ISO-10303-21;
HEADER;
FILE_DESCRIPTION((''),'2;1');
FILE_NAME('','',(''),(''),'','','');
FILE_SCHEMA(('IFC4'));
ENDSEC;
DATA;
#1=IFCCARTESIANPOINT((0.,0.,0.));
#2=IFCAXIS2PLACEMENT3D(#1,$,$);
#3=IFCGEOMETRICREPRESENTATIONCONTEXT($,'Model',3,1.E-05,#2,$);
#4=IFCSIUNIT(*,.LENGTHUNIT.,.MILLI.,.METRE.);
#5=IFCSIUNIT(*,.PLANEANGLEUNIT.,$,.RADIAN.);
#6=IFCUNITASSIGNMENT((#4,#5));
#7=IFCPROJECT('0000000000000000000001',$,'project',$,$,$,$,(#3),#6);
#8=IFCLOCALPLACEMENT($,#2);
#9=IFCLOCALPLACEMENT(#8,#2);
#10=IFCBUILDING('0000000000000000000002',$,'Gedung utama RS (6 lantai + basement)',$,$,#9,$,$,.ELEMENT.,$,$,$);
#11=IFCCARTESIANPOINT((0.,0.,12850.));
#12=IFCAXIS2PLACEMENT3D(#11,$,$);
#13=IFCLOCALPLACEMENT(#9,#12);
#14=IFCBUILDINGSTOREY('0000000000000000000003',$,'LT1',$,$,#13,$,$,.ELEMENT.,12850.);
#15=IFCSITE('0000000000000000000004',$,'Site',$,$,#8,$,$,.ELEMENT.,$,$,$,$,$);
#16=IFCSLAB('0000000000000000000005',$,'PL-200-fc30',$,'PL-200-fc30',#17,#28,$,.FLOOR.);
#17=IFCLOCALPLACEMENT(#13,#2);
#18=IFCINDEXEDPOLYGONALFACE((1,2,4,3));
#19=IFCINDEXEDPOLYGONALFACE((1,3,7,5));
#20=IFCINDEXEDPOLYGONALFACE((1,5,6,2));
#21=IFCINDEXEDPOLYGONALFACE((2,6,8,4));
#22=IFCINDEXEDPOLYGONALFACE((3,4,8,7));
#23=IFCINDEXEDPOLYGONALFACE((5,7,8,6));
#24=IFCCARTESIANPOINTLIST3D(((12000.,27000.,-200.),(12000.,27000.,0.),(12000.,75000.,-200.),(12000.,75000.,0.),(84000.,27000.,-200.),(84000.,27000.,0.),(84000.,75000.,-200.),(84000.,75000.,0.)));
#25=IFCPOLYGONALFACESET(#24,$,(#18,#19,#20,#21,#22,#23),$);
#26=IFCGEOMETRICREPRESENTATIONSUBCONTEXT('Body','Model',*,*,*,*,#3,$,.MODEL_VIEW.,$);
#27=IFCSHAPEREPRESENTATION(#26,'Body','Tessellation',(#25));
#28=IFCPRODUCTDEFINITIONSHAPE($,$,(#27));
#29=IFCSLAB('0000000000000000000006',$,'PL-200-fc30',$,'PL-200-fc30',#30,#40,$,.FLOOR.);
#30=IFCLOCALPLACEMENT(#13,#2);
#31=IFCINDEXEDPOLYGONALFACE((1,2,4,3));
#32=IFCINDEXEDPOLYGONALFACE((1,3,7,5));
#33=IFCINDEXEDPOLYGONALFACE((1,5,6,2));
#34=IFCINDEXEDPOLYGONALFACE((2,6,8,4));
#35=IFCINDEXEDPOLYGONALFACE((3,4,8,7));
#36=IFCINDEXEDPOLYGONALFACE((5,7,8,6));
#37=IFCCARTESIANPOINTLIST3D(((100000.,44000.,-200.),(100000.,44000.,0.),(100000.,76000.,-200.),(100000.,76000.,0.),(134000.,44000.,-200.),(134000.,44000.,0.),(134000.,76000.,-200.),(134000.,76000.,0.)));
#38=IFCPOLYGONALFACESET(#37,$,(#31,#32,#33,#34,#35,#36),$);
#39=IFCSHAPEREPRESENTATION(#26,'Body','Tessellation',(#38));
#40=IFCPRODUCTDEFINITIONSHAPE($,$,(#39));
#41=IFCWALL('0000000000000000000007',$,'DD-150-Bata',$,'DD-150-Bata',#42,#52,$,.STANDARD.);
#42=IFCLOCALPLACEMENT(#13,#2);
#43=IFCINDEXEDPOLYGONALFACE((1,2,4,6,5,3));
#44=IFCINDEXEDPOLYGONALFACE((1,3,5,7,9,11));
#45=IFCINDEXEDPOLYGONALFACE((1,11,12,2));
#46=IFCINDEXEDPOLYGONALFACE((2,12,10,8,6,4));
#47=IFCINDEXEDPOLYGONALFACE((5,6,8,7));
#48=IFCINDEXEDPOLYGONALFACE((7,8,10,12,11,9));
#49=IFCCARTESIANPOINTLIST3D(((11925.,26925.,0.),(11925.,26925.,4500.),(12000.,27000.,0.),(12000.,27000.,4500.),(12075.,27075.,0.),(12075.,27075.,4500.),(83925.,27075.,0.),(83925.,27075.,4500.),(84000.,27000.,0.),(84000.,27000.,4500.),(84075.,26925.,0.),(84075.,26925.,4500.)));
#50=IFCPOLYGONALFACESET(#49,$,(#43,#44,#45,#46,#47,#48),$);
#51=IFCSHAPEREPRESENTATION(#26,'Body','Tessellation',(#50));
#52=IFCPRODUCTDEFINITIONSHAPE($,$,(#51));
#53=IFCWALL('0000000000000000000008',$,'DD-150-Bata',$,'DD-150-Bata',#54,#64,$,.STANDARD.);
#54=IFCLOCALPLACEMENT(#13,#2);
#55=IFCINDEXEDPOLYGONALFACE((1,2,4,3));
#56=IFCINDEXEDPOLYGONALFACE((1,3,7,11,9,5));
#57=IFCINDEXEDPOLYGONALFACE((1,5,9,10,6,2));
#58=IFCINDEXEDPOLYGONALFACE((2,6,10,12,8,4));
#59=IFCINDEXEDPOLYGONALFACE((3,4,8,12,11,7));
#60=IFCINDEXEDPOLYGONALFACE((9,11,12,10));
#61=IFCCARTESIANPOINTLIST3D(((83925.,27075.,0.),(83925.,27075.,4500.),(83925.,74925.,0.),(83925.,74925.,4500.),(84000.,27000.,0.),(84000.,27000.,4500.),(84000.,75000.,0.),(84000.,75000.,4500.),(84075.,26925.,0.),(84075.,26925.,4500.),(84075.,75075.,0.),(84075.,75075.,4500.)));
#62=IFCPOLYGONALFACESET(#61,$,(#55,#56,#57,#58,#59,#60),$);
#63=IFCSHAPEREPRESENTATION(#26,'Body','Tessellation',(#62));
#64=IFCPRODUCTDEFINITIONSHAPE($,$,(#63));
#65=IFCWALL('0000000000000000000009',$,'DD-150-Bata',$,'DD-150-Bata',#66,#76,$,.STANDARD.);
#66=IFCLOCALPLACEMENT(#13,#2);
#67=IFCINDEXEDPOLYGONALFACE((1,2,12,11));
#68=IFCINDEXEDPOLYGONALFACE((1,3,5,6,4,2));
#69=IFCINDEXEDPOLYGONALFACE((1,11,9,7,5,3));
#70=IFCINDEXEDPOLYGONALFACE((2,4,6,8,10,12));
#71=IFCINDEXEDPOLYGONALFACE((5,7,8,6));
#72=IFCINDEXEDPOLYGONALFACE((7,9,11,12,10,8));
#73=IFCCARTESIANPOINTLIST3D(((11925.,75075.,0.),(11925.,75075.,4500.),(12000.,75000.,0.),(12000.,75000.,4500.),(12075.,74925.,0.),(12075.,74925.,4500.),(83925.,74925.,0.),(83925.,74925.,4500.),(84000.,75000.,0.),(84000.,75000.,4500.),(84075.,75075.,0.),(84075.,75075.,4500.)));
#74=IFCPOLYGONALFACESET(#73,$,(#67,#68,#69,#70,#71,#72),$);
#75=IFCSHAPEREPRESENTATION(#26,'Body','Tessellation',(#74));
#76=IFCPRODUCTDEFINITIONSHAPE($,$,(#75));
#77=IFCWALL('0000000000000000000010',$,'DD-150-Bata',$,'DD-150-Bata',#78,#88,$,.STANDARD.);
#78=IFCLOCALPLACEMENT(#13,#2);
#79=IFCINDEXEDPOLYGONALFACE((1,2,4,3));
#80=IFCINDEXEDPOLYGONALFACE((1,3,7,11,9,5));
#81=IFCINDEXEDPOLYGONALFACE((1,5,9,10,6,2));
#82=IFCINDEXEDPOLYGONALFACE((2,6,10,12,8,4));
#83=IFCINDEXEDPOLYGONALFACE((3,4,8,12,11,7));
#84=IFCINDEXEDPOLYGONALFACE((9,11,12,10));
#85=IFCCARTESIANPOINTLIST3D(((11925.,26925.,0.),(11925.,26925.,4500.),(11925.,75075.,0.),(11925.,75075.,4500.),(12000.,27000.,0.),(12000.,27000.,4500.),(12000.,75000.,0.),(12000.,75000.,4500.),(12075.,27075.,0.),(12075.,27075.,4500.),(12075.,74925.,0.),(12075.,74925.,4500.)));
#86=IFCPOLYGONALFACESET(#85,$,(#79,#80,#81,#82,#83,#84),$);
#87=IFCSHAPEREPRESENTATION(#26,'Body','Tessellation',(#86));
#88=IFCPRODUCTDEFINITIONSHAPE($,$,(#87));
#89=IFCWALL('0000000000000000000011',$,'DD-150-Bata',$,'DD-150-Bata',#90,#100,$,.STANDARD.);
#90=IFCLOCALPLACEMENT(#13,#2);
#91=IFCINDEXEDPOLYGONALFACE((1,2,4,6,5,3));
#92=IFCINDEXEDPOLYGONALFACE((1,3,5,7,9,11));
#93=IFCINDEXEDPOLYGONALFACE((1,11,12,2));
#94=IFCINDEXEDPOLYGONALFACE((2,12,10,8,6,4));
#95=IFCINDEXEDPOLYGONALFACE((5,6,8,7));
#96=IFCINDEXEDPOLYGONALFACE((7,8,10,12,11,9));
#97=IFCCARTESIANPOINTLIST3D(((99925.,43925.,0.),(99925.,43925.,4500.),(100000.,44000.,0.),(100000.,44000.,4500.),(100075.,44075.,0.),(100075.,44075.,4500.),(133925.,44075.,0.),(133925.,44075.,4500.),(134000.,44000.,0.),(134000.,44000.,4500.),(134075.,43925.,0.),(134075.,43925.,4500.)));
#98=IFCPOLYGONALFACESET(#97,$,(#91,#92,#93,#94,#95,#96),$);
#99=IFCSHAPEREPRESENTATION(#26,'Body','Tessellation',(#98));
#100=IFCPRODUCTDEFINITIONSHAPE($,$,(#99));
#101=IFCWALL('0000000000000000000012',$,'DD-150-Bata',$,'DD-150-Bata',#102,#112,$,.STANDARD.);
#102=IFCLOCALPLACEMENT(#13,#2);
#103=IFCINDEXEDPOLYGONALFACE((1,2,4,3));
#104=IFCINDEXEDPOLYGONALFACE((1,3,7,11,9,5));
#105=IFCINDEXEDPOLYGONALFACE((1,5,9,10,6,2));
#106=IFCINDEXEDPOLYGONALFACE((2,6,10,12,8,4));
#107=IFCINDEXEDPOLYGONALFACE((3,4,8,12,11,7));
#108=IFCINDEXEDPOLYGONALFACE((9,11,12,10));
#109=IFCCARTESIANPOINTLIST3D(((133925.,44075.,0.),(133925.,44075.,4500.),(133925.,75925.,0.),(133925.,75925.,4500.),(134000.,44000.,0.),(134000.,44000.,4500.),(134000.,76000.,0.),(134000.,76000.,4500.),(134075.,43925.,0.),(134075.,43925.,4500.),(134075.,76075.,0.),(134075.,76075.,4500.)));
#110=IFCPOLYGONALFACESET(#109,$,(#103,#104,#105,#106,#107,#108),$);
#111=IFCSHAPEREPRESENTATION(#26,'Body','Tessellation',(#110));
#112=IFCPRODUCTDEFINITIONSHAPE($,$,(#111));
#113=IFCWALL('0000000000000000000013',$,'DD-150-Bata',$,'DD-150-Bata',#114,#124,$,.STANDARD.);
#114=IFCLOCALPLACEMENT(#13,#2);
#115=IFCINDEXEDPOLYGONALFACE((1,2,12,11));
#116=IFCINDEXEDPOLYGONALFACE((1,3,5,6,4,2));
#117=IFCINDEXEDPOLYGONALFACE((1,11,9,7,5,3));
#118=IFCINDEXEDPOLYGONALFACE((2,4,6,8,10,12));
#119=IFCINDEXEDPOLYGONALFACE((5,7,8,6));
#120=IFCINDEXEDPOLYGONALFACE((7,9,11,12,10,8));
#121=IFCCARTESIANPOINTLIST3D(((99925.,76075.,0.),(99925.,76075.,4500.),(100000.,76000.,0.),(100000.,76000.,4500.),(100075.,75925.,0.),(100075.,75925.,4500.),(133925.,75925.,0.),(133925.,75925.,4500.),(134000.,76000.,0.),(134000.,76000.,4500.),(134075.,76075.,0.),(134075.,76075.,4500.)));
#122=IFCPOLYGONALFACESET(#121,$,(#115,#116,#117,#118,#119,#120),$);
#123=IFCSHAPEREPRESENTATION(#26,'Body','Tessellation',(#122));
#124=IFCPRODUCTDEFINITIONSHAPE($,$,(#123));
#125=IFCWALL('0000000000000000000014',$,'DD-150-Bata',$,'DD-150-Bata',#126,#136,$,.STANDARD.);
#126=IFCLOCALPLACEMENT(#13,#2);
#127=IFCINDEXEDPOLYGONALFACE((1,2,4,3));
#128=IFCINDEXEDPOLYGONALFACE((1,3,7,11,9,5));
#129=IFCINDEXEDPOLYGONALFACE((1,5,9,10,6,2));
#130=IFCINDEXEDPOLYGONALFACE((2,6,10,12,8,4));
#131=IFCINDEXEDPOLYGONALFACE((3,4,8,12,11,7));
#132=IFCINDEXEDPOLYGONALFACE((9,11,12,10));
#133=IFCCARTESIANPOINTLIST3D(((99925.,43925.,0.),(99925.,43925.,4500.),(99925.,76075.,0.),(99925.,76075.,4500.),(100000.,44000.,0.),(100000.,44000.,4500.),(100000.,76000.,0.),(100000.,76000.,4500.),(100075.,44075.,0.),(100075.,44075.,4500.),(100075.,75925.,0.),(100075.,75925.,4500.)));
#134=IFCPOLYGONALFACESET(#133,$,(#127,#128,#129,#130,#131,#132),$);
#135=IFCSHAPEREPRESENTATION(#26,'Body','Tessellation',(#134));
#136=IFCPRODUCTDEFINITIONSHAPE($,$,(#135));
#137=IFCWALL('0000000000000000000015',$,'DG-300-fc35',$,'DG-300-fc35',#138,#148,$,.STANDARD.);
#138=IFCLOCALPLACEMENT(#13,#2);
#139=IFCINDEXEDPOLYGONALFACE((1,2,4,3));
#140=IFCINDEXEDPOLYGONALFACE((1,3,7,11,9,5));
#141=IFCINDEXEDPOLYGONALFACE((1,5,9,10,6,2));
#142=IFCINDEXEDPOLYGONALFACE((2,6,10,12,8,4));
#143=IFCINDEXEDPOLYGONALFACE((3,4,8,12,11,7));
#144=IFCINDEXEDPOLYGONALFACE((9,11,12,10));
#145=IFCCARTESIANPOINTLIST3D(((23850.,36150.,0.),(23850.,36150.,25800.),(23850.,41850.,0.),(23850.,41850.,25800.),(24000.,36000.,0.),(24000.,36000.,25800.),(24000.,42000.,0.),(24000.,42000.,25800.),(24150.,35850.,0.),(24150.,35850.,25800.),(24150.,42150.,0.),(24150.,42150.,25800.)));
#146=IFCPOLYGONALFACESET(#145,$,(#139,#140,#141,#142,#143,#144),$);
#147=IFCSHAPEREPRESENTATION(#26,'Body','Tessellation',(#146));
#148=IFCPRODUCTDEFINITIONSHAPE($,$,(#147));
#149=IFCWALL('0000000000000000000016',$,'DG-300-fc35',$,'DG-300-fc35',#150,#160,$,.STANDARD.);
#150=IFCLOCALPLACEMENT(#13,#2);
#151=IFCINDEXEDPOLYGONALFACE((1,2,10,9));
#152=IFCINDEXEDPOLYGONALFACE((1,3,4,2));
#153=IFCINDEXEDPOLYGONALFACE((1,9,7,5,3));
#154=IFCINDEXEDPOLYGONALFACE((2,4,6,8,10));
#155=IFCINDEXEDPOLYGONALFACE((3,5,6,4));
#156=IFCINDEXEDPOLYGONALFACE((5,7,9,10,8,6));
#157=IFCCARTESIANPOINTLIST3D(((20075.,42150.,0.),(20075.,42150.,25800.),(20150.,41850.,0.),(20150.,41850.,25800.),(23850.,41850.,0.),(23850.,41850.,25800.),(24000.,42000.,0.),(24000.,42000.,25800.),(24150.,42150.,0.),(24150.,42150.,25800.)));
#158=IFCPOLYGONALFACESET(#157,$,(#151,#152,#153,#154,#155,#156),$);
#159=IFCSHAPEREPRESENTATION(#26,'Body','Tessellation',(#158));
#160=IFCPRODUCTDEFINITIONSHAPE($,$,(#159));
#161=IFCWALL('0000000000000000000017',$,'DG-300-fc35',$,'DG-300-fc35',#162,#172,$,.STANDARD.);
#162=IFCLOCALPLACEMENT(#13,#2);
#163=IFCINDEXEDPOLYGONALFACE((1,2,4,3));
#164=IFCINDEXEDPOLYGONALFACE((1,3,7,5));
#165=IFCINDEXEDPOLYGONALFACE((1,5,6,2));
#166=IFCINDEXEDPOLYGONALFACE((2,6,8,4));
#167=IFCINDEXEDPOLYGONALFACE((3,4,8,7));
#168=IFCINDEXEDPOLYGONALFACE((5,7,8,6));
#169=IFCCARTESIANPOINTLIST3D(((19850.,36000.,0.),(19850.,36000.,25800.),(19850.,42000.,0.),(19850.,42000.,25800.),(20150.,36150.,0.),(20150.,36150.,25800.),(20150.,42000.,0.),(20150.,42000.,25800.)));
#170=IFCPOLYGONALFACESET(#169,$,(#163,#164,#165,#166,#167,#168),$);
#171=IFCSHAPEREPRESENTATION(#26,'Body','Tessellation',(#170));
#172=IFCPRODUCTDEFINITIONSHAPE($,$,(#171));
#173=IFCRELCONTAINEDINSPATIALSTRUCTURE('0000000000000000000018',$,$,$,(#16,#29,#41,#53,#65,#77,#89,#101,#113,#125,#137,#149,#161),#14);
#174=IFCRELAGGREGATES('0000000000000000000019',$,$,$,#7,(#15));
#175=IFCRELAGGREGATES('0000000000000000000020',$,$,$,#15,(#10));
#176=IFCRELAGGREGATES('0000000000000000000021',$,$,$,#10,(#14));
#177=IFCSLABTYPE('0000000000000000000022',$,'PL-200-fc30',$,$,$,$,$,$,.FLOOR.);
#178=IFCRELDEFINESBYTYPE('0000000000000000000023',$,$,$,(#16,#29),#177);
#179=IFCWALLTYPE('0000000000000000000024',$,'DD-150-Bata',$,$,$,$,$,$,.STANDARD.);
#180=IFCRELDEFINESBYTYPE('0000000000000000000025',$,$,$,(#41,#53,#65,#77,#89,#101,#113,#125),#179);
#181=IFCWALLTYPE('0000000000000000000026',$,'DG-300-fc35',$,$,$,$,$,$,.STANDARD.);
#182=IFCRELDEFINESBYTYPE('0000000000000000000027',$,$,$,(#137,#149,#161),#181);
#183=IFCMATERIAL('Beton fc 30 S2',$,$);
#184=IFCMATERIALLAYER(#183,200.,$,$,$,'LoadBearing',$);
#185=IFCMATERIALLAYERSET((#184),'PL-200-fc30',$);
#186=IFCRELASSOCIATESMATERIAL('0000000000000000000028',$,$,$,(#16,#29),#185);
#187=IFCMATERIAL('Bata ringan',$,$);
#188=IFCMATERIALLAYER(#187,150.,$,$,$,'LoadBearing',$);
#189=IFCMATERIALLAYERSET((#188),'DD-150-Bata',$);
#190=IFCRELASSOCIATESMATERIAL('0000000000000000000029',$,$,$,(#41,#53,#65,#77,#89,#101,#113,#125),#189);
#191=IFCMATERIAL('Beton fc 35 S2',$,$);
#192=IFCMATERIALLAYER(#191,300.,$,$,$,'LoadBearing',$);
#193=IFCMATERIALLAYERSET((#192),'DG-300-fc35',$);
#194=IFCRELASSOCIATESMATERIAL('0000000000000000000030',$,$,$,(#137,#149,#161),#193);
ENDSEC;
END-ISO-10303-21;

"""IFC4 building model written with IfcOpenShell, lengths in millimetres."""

from ifc_helpers import new_model, si_unit, frame, origin, place, context, subcontext, project, spatial, polyline, outline, extrude, material, layer, layer_set, layer_usage, type_object, element, save


model = new_model("IFC4")

# Units and contexts
model_context = context("Model", 3, precision=1e-05, world=origin())
body_context = subcontext(model_context, "Body", "Model", "MODEL_VIEW")
ifc_project = project(units=[si_unit("LENGTHUNIT", "METRE", prefix="MILLI"), si_unit("PLANEANGLEUNIT", "RADIAN")], contexts=[model_context])

# Site, building, storey
site_placement = place(None, origin())
site = spatial("IfcSite", under=ifc_project, at=site_placement, Name="Site", CompositionType="ELEMENT")
building_placement = place(site_placement, origin())
building = spatial("IfcBuilding", under=site, at=building_placement, Name="Gedung utama RS (6 lantai + basement)", CompositionType="ELEMENT")
storey_placement = place(building_placement, frame((0.0, 0.0, 12850.0)))
storey = spatial("IfcBuildingStorey", under=building, at=storey_placement, Name="LT1", CompositionType="ELEMENT", Elevation=12850.0)

# Slabs
ifc_material_1 = material(Name="Beton fc 30 S2")
ifc_layer_1 = layer(ifc_material_1, 200.0, Category="LoadBearing")
ifc_layer_set_1 = layer_set([ifc_layer_1], Name="PL-200-fc30")
ifc_layer_usage_1 = layer_usage(ifc_layer_set_1, "AXIS3", "NEGATIVE", 0.0)
slab_type = type_object("IfcSlabType", Name="PL-200-fc30", PredefinedType="FLOOR")
slab_1_placement = place(storey_placement, origin())
element("IfcSlab", 1, at=slab_1_placement, inside=storey, type_object=slab_type, material=ifc_layer_usage_1, Name="PL-200-fc30", ObjectType="PL-200-fc30", PredefinedType="FLOOR", context=body_context, shape_type="SweptSolid", body=[
    extrude(outline(polyline([(12000.0, 27000.0), (84000.0, 27000.0), (84000.0, 75000.0), (12000.0, 75000.0), (12000.0, 27000.0)])), frame((0.0, 0.0, -200.0)), (0.0, 0.0, 1.0), 200.0),
])
slab_2_placement = place(storey_placement, origin())
element("IfcSlab", 2, at=slab_2_placement, inside=storey, type_object=slab_type, material=ifc_layer_usage_1, Name="PL-200-fc30", ObjectType="PL-200-fc30", PredefinedType="FLOOR", context=body_context, shape_type="SweptSolid", body=[
    extrude(outline(polyline([(100000.0, 44000.0), (134000.0, 44000.0), (134000.0, 76000.0), (100000.0, 76000.0), (100000.0, 44000.0)])), frame((0.0, 0.0, -200.0)), (0.0, 0.0, 1.0), 200.0),
])

# Walls
ifc_material_2 = material(Name="Bata ringan")
ifc_layer_2 = layer(ifc_material_2, 150.0, Category="LoadBearing")
ifc_layer_set_2 = layer_set([ifc_layer_2], Name="DD-150-Bata")
ifc_layer_usage_2 = layer_usage(ifc_layer_set_2, "AXIS2", "NEGATIVE", 75.0)
wall_type_1 = type_object("IfcWallType", Name="DD-150-Bata", PredefinedType="STANDARD")
wall_1_placement = place(storey_placement, frame((12000.0, 27000.0, 0.0), z_axis=(0.0, 0.0, 1.0), x_axis=(1.0, 0.0, 0.0)))
element("IfcWall", 3, at=wall_1_placement, inside=storey, type_object=wall_type_1, material=ifc_layer_usage_2, Name="DD-150-Bata", ObjectType="DD-150-Bata", PredefinedType="STANDARD", context=body_context, shape_type="SweptSolid", body=[
    extrude(outline(polyline([(-75.0, -75.0), (0.0, 0.0), (75.0, 75.0), (71925.0, 75.0), (72000.0, 0.0), (72075.0, -75.0), (-75.0, -75.0)])), origin(), (0.0, 0.0, 1.0), 4500.0),
])
wall_2_placement = place(storey_placement, frame((84000.0, 27000.0, 0.0), z_axis=(0.0, 0.0, 1.0), x_axis=(0.0, 1.0, 0.0)))
element("IfcWall", 4, at=wall_2_placement, inside=storey, type_object=wall_type_1, material=ifc_layer_usage_2, Name="DD-150-Bata", ObjectType="DD-150-Bata", PredefinedType="STANDARD", context=body_context, shape_type="SweptSolid", body=[
    extrude(outline(polyline([(-75.0, -75.0), (0.0, 0.0), (75.0, 75.0), (47925.0, 75.0), (48000.0, 0.0), (48075.0, -75.0), (-75.0, -75.0)])), origin(), (0.0, 0.0, 1.0), 4500.0),
])
wall_3_placement = place(storey_placement, frame((84000.0, 75000.0, 0.0), z_axis=(0.0, 0.0, 1.0), x_axis=(-1.0, 0.0, 0.0)))
element("IfcWall", 5, at=wall_3_placement, inside=storey, type_object=wall_type_1, material=ifc_layer_usage_2, Name="DD-150-Bata", ObjectType="DD-150-Bata", PredefinedType="STANDARD", context=body_context, shape_type="SweptSolid", body=[
    extrude(outline(polyline([(-75.0, -75.0), (0.0, 0.0), (75.0, 75.0), (71925.0, 75.0), (72000.0, 0.0), (72075.0, -75.0), (-75.0, -75.0)])), origin(), (0.0, 0.0, 1.0), 4500.0),
])
wall_4_placement = place(storey_placement, frame((12000.0, 75000.0, 0.0), z_axis=(0.0, 0.0, 1.0), x_axis=(0.0, -1.0, 0.0)))
element("IfcWall", 6, at=wall_4_placement, inside=storey, type_object=wall_type_1, material=ifc_layer_usage_2, Name="DD-150-Bata", ObjectType="DD-150-Bata", PredefinedType="STANDARD", context=body_context, shape_type="SweptSolid", body=[
    extrude(outline(polyline([(-75.0, -75.0), (0.0, 0.0), (75.0, 75.0), (47925.0, 75.0), (48000.0, 0.0), (48075.0, -75.0), (-75.0, -75.0)])), origin(), (0.0, 0.0, 1.0), 4500.0),
])
wall_5_placement = place(storey_placement, frame((100000.0, 44000.0, 0.0), z_axis=(0.0, 0.0, 1.0), x_axis=(1.0, 0.0, 0.0)))
element("IfcWall", 7, at=wall_5_placement, inside=storey, type_object=wall_type_1, material=ifc_layer_usage_2, Name="DD-150-Bata", ObjectType="DD-150-Bata", PredefinedType="STANDARD", context=body_context, shape_type="SweptSolid", body=[
    extrude(outline(polyline([(-75.0, -75.0), (0.0, 0.0), (75.0, 75.0), (33925.0, 75.0), (34000.0, 0.0), (34075.0, -75.0), (-75.0, -75.0)])), origin(), (0.0, 0.0, 1.0), 4500.0),
])
wall_6_placement = place(storey_placement, frame((134000.0, 44000.0, 0.0), z_axis=(0.0, 0.0, 1.0), x_axis=(0.0, 1.0, 0.0)))
element("IfcWall", 8, at=wall_6_placement, inside=storey, type_object=wall_type_1, material=ifc_layer_usage_2, Name="DD-150-Bata", ObjectType="DD-150-Bata", PredefinedType="STANDARD", context=body_context, shape_type="SweptSolid", body=[
    extrude(outline(polyline([(-75.0, -75.0), (0.0, 0.0), (75.0, 75.0), (31925.0, 75.0), (32000.0, 0.0), (32075.0, -75.0), (-75.0, -75.0)])), origin(), (0.0, 0.0, 1.0), 4500.0),
])
wall_7_placement = place(storey_placement, frame((134000.0, 76000.0, 0.0), z_axis=(0.0, 0.0, 1.0), x_axis=(-1.0, 0.0, 0.0)))
element("IfcWall", 9, at=wall_7_placement, inside=storey, type_object=wall_type_1, material=ifc_layer_usage_2, Name="DD-150-Bata", ObjectType="DD-150-Bata", PredefinedType="STANDARD", context=body_context, shape_type="SweptSolid", body=[
    extrude(outline(polyline([(-75.0, -75.0), (0.0, 0.0), (75.0, 75.0), (33925.0, 75.0), (34000.0, 0.0), (34075.0, -75.0), (-75.0, -75.0)])), origin(), (0.0, 0.0, 1.0), 4500.0),
])
wall_8_placement = place(storey_placement, frame((100000.0, 76000.0, 0.0), z_axis=(0.0, 0.0, 1.0), x_axis=(0.0, -1.0, 0.0)))
element("IfcWall", 10, at=wall_8_placement, inside=storey, type_object=wall_type_1, material=ifc_layer_usage_2, Name="DD-150-Bata", ObjectType="DD-150-Bata", PredefinedType="STANDARD", context=body_context, shape_type="SweptSolid", body=[
    extrude(outline(polyline([(-75.0, -75.0), (0.0, 0.0), (75.0, 75.0), (31925.0, 75.0), (32000.0, 0.0), (32075.0, -75.0), (-75.0, -75.0)])), origin(), (0.0, 0.0, 1.0), 4500.0),
])
ifc_material_3 = material(Name="Beton fc 35 S2")
ifc_layer_3 = layer(ifc_material_3, 300.0, Category="LoadBearing")
ifc_layer_set_3 = layer_set([ifc_layer_3], Name="DG-300-fc35")
ifc_layer_usage_3 = layer_usage(ifc_layer_set_3, "AXIS2", "NEGATIVE", 150.0)
wall_type_2 = type_object("IfcWallType", Name="DG-300-fc35", PredefinedType="STANDARD")
wall_9_placement = place(storey_placement, frame((24000.0, 36000.0, 0.0), z_axis=(0.0, 0.0, 1.0), x_axis=(0.0, 1.0, 0.0)))
element("IfcWall", 11, at=wall_9_placement, inside=storey, type_object=wall_type_2, material=ifc_layer_usage_3, Name="DG-300-fc35", ObjectType="DG-300-fc35", PredefinedType="STANDARD", context=body_context, shape_type="SweptSolid", body=[
    extrude(outline(polyline([(-150.0, -150.0), (0.0, 0.0), (150.0, 150.0), (5850.0, 150.0), (6000.0, 0.0), (6150.0, -150.0), (-150.0, -150.0)])), origin(), (0.0, 0.0, 1.0), 25800.0),
])
wall_10_placement = place(storey_placement, frame((24000.0, 42000.0, 0.0), z_axis=(0.0, 0.0, 1.0), x_axis=(-1.0, 0.0, 0.0)))
element("IfcWall", 12, at=wall_10_placement, inside=storey, type_object=wall_type_2, material=ifc_layer_usage_3, Name="DG-300-fc35", ObjectType="DG-300-fc35", PredefinedType="STANDARD", context=body_context, shape_type="SweptSolid", body=[
    extrude(outline(polyline([(-150.0, -150.0), (0.0, 0.0), (150.0, 150.0), (3850.0, 150.0), (3925.0, -150.0), (-150.0, -150.0)])), origin(), (0.0, 0.0, 1.0), 25800.0),
])
wall_11_placement = place(storey_placement, frame((20000.0, 42000.0, 0.0), z_axis=(0.0, 0.0, 1.0), x_axis=(0.0, -1.0, 0.0)))
element("IfcWall", 13, at=wall_11_placement, inside=storey, type_object=wall_type_2, material=ifc_layer_usage_3, Name="DG-300-fc35", ObjectType="DG-300-fc35", PredefinedType="STANDARD", context=body_context, shape_type="SweptSolid", body=[
    extrude(outline(polyline([(0.0, -150.0), (0.0, 150.0), (5850.0, 150.0), (6000.0, -150.0), (0.0, -150.0)])), origin(), (0.0, 0.0, 1.0), 25800.0),
])

save(model, "model.ifc")
